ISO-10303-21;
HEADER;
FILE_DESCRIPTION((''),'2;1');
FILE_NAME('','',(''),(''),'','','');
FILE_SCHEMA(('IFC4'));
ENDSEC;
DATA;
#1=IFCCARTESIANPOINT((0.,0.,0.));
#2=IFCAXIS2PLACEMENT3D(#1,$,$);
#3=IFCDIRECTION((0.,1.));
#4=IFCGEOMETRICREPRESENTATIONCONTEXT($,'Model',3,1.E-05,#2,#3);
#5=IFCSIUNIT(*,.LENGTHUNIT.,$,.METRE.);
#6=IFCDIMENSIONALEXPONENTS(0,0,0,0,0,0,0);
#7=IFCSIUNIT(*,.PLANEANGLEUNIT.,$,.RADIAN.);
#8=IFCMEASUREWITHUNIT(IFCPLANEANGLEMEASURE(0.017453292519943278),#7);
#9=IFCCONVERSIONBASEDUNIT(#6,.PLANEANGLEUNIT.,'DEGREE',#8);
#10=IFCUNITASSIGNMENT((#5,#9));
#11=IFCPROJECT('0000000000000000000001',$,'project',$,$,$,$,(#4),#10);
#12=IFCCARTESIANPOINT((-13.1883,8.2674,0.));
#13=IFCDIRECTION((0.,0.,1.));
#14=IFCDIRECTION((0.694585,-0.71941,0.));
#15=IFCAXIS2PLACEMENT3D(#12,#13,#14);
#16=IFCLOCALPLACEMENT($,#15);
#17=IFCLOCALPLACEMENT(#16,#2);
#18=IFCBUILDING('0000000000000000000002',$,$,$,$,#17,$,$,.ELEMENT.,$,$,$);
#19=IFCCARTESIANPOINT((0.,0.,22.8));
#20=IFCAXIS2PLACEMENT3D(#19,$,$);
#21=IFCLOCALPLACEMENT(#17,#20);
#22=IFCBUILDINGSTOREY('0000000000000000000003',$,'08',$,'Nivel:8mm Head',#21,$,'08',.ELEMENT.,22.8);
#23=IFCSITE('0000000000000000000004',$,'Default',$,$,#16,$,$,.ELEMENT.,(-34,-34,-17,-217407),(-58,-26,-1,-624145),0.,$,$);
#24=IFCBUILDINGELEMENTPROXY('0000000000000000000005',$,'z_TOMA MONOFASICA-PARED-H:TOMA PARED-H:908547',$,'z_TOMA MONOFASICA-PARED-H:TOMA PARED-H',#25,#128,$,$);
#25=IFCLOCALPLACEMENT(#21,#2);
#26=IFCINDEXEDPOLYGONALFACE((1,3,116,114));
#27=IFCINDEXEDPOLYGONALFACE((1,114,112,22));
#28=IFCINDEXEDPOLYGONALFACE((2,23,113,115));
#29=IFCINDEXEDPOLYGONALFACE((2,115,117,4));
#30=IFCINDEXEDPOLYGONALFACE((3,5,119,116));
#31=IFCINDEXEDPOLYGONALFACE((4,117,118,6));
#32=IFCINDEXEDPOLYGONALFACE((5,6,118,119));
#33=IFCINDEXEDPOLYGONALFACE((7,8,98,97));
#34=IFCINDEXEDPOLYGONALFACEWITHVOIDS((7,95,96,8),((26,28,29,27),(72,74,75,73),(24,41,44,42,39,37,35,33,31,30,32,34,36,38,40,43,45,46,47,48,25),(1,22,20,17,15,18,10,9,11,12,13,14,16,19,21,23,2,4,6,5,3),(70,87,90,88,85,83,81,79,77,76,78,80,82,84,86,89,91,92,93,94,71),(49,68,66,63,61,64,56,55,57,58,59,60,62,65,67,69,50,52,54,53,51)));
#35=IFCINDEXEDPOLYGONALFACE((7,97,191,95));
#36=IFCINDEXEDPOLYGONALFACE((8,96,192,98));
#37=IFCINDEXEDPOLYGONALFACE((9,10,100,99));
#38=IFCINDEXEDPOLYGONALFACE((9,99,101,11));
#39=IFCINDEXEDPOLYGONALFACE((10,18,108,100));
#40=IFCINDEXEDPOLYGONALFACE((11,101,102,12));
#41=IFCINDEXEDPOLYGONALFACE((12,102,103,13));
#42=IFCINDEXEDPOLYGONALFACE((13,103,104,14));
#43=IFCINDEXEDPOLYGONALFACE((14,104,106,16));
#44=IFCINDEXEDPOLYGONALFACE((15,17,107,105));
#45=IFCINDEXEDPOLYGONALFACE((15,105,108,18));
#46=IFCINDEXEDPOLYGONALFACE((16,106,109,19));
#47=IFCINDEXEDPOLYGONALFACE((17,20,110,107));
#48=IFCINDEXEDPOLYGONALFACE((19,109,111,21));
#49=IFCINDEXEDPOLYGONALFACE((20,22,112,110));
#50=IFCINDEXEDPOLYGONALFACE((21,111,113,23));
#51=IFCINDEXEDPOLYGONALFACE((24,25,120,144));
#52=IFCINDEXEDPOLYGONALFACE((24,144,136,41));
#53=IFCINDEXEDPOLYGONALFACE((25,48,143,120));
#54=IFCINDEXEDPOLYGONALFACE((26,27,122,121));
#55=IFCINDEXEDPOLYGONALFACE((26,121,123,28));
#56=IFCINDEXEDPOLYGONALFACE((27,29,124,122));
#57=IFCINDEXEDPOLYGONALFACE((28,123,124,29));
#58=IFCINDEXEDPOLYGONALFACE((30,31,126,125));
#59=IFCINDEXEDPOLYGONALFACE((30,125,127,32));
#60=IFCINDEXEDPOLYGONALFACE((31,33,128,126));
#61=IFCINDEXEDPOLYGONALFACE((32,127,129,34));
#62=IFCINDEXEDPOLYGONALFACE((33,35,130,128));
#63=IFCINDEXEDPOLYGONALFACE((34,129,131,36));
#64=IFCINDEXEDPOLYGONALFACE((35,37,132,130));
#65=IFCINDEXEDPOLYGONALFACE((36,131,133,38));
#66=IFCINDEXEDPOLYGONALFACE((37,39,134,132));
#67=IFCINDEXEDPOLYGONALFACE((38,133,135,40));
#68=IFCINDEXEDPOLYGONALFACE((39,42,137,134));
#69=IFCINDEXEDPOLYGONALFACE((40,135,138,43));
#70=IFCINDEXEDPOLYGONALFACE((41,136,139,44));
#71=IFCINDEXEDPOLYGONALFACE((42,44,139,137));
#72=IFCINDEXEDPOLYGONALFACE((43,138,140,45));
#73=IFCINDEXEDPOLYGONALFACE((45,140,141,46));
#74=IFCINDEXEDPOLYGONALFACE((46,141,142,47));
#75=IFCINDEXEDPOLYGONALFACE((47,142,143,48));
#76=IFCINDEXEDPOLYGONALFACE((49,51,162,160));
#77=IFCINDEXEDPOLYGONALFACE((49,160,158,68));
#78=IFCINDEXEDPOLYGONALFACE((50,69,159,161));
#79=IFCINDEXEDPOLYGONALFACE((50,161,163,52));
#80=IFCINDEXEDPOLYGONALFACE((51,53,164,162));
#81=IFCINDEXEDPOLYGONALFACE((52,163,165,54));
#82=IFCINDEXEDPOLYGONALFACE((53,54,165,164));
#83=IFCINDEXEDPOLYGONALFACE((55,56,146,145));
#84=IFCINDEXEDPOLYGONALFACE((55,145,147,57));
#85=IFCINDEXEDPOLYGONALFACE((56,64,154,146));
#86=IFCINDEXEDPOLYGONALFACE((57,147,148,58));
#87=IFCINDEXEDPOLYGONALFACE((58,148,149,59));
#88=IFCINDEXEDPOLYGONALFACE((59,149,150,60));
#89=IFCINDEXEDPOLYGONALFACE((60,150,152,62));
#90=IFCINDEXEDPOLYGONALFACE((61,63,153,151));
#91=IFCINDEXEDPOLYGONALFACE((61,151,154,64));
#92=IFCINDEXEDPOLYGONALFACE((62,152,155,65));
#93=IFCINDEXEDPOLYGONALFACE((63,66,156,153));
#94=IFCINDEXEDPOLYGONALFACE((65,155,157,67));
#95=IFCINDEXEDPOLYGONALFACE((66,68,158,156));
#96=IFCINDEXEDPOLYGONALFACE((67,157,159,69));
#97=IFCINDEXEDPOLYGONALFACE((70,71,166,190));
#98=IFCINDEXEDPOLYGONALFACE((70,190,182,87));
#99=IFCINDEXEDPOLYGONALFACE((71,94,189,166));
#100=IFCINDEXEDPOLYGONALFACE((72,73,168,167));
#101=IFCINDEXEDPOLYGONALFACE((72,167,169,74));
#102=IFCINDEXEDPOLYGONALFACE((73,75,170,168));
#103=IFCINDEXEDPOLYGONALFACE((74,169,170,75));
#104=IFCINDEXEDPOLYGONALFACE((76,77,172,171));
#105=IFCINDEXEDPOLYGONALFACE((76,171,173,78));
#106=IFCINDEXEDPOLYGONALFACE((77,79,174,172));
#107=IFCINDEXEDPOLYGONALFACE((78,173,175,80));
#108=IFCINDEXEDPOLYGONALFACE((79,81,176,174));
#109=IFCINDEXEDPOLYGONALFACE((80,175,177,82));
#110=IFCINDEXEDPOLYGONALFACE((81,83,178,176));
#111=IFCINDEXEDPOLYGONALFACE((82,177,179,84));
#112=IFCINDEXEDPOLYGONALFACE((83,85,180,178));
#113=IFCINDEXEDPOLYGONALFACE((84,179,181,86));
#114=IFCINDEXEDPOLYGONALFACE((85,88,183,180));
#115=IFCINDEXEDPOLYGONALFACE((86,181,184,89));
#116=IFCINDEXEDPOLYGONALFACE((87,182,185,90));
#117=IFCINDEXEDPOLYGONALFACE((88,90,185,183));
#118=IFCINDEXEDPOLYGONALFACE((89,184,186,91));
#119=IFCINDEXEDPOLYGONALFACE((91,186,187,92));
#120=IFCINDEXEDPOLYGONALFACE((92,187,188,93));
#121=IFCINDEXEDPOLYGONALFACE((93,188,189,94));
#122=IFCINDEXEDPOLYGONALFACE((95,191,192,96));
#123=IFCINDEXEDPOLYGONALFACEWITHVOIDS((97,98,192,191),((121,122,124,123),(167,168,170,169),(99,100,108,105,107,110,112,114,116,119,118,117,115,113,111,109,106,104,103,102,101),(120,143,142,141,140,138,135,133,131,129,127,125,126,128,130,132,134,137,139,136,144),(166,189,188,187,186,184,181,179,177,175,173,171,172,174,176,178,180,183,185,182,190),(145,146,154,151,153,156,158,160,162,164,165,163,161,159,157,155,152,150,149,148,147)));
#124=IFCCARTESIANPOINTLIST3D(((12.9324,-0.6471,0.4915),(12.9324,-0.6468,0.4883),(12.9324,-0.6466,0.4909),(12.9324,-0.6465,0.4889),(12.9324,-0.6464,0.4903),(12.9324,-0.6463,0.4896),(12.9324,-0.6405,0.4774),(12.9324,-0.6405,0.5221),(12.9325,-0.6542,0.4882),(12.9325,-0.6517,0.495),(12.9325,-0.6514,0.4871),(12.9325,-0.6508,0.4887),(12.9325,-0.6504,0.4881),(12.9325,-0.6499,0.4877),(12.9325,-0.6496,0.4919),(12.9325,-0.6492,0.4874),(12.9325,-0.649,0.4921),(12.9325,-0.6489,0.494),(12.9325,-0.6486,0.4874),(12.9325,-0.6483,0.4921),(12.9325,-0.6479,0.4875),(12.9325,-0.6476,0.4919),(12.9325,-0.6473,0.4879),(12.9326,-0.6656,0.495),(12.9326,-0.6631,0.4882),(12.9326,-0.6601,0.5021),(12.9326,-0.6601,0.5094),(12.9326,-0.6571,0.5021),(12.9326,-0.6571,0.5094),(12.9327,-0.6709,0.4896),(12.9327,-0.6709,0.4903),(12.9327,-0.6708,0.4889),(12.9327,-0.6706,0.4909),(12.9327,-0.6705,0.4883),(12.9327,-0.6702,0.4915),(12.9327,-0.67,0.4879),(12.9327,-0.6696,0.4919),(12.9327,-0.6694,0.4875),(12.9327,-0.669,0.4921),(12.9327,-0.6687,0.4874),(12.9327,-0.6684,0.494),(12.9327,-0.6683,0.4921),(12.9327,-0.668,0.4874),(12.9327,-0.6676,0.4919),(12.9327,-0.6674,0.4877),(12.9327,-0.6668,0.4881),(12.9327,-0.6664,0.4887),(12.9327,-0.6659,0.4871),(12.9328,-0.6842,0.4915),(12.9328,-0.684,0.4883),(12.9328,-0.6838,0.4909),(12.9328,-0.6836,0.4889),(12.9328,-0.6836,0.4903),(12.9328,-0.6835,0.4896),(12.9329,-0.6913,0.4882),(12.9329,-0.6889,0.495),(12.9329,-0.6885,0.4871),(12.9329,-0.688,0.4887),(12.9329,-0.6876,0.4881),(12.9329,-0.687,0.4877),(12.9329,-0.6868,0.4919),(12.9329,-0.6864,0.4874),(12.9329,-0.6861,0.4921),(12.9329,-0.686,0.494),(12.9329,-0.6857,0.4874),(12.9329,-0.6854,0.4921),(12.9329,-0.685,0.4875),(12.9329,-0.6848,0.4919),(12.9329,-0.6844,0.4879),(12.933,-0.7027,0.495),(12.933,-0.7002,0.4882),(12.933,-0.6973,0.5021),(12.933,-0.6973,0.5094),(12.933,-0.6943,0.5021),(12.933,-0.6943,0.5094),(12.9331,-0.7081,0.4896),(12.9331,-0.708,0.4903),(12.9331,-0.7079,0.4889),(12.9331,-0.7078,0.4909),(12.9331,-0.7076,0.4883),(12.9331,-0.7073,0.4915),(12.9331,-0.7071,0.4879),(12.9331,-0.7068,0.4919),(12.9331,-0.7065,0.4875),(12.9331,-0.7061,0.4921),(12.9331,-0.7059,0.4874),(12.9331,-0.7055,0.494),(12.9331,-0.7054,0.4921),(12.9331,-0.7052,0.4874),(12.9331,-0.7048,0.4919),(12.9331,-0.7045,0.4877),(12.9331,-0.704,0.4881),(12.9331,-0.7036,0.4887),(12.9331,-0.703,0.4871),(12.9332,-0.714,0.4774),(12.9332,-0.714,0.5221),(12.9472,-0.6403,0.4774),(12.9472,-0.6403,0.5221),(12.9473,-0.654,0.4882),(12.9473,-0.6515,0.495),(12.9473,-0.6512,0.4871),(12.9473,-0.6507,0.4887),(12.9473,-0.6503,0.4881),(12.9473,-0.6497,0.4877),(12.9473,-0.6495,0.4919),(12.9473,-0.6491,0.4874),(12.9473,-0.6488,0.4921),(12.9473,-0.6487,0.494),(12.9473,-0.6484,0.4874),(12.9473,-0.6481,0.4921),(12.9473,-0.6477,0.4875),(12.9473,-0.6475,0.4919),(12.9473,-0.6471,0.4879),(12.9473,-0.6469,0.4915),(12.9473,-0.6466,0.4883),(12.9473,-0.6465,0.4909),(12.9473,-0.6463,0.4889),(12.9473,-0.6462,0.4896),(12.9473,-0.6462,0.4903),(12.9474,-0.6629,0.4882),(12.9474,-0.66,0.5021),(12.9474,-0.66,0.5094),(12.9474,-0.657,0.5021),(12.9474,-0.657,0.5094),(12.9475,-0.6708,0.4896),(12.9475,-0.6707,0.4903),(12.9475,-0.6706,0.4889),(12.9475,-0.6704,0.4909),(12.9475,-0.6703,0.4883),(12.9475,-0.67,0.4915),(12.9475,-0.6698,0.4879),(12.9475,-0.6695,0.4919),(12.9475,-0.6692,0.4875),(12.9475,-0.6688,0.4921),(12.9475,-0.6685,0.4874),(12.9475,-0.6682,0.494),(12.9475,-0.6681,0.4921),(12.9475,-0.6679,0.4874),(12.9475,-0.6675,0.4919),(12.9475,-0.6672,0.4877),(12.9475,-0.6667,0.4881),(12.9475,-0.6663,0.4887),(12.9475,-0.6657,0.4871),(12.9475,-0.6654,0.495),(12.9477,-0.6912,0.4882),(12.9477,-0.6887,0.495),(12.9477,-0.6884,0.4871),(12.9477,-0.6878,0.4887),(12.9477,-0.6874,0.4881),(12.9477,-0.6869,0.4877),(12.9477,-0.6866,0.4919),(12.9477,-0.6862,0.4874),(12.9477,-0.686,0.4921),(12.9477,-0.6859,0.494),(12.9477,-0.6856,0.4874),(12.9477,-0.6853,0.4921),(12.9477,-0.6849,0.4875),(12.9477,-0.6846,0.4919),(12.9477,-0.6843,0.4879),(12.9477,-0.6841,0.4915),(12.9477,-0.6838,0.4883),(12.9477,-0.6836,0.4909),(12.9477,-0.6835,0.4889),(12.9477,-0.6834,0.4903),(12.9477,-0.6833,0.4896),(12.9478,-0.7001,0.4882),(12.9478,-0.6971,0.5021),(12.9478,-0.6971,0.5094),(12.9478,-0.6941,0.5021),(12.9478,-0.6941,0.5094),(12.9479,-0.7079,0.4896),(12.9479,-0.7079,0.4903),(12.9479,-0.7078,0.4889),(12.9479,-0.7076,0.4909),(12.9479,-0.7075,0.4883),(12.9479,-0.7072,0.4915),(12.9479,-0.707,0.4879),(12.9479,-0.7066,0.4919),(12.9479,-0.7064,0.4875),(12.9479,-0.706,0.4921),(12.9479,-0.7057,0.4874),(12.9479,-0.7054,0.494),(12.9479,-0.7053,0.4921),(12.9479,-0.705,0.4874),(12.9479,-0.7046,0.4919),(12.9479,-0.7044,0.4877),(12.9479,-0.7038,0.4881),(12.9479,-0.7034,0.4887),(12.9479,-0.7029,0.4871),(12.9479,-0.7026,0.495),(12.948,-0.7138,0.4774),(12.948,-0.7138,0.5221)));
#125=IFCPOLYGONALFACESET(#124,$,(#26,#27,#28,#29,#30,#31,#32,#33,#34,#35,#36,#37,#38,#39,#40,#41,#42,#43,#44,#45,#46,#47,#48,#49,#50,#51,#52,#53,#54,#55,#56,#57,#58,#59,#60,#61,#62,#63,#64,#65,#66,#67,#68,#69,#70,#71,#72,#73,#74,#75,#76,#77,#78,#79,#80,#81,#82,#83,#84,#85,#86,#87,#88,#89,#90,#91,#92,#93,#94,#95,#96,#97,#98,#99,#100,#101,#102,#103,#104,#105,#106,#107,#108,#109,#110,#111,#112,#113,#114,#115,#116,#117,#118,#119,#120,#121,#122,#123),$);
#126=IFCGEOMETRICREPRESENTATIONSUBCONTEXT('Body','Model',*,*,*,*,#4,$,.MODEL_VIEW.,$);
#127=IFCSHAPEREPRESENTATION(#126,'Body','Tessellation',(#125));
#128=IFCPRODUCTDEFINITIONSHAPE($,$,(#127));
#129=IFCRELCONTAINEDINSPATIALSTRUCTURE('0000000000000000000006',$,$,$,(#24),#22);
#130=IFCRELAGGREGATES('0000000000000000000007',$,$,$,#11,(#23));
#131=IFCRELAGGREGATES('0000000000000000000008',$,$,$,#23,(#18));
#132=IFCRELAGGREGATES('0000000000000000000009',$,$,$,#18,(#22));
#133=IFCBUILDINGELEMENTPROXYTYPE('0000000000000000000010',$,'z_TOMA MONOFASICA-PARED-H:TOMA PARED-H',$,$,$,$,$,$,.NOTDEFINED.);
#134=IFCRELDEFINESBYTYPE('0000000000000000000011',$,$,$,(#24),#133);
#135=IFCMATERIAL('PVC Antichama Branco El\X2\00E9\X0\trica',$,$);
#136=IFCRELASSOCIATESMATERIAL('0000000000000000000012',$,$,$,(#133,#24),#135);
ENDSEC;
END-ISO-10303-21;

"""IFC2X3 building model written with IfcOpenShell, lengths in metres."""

from ifc_helpers import new_model, entity, si_unit, converted_unit, direction, frame, frame_2d, origin, place, context, subcontext, project, spatial, polyline, circle_curve, parameter, trimmed, segment, composite_curve, outline, extrude, source, transform, mapped, material, type_object, type_shapes, element, save


model = new_model("IFC2X3")

# Units and contexts
model_context = context("Model", 3, precision=1e-05, world=origin(), true_north=direction((0.0, 1.0)))
body_context = subcontext(model_context, "Body", "Model", "MODEL_VIEW")
ifc_project = project(units=[si_unit("LENGTHUNIT", "METRE"), converted_unit("PLANEANGLEUNIT", "DEGREE", entity("IfcPlaneAngleMeasure", 0.017453292519943278), si_unit("PLANEANGLEUNIT", "RADIAN"), dimensions=[0, 0, 0, 0, 0, 0, 0])], contexts=[model_context])

# Site, building, storey
site_placement = place(None, frame((-13.1883, 8.2674, 0.0), z_axis=(0.0, 0.0, 1.0), x_axis=(0.694585, -0.71941, 0.0)))
site = spatial("IfcSite", under=ifc_project, at=site_placement, Name="Default", CompositionType="ELEMENT", RefLatitude=(-34, -34, -17, -217407), RefLongitude=(-58, -26, -1, -624145), RefElevation=0.0)
building_placement = place(site_placement, origin())
building = spatial("IfcBuilding", under=site, at=building_placement, CompositionType="ELEMENT")
storey_placement = place(building_placement, frame((0.0, 0.0, 22.8)))
storey = spatial("IfcBuildingStorey", under=building, at=storey_placement, Name="08", ObjectType="Nivel:8mm Head", LongName="08", CompositionType="ELEMENT", Elevation=22.8)

# Building element proxy
ifc_material_1 = material(Name="PVC Antichama Branco Elétrica")
building_element_proxy_type_1 = type_object("IfcBuildingElementProxyType", Name="z_TOMA MONOFASICA-PARED-H:TOMA PARED-H", PredefinedType="NOTDEFINED", material=ifc_material_1)
shared_shape_1 = source(origin(), body_context, "Body", "SweptSolid", [
    extrude(outline(polyline([(-0.0368, -0.0223), (0.0368, -0.0223), (0.0368, 0.0223), (-0.0368, 0.0223), (-0.0368, -0.0223)]), holes=[composite_curve([segment(polyline([(0.0141, 0.0115), (0.0116, 0.0047)]), True, "CONTINUOUS"), segment(polyline([(0.0116, 0.0047), (0.0088, 0.0057)]), True, "CONTINUOUS"), segment(polyline([(0.0088, 0.0057), (0.0096, 0.0078)]), True, "CONTINUOUS"), segment(trimmed(circle_curve(frame_2d((0.0087, 0.0099), x_axis=(1.0, 0.0)), 0.0024), [parameter(27.118901)], [parameter(292.881099)], True, "PARAMETER"), False, "CONTINUOUS"), segment(polyline([(0.0108, 0.011), (0.0113, 0.0126)]), True, "CONTINUOUS"), segment(polyline([(0.0113, 0.0126), (0.0141, 0.0115)]), True, "CONTINUOUS")], self_intersect=False), composite_curve([segment(polyline([(0.0255, 0.0047), (0.023, 0.0115)]), True, "CONTINUOUS"), segment(polyline([(0.023, 0.0115), (0.0258, 0.0126)]), True, "CONTINUOUS"), segment(polyline([(0.0258, 0.0126), (0.0264, 0.011)]), True, "CONTINUOUS"), segment(trimmed(circle_curve(frame_2d((0.0285, 0.0099), x_axis=(1.0, 0.0)), 0.0024), [parameter(247.118901)], [parameter(152.881099)], True, "PARAMETER"), False, "CONTINUOUS"), segment(polyline([(0.0276, 0.0078), (0.0283, 0.0057)]), True, "CONTINUOUS"), segment(polyline([(0.0283, 0.0057), (0.0255, 0.0047)]), True, "CONTINUOUS")], self_intersect=False), polyline([(0.0201, -0.0024), (0.0201, -0.0097), (0.0171, -0.0097), (0.0171, -0.0024), (0.0201, -0.0024)]), composite_curve([segment(polyline([(-0.0141, 0.0115), (-0.0113, 0.0126)]), True, "CONTINUOUS"), segment(polyline([(-0.0113, 0.0126), (-0.0108, 0.011)]), True, "CONTINUOUS"), segment(trimmed(circle_curve(frame_2d((-0.0087, 0.0099), x_axis=(1.0, 0.0)), 0.0024), [parameter(247.118901)], [parameter(152.881099)], True, "PARAMETER"), False, "CONTINUOUS"), segment(polyline([(-0.0096, 0.0078), (-0.0088, 0.0057)]), True, "CONTINUOUS"), segment(polyline([(-0.0088, 0.0057), (-0.0116, 0.0047)]), True, "CONTINUOUS"), segment(polyline([(-0.0116, 0.0047), (-0.0141, 0.0115)]), True, "CONTINUOUS")], self_intersect=False), composite_curve([segment(polyline([(-0.0255, 0.0047), (-0.0283, 0.0057)]), True, "CONTINUOUS"), segment(polyline([(-0.0283, 0.0057), (-0.0276, 0.0078)]), True, "CONTINUOUS"), segment(trimmed(circle_curve(frame_2d((-0.0285, 0.0099), x_axis=(1.0, 0.0)), 0.0024), [parameter(27.118901)], [parameter(292.881099)], True, "PARAMETER"), False, "CONTINUOUS"), segment(polyline([(-0.0264, 0.011), (-0.0258, 0.0126)]), True, "CONTINUOUS"), segment(polyline([(-0.0258, 0.0126), (-0.023, 0.0115)]), True, "CONTINUOUS"), segment(polyline([(-0.023, 0.0115), (-0.0255, 0.0047)]), True, "CONTINUOUS")], self_intersect=False), polyline([(-0.0201, -0.0024), (-0.0171, -0.0024), (-0.0171, -0.0097), (-0.0201, -0.0097), (-0.0201, -0.0024)])]), frame((0.0, -0.005, 0.0223), z_axis=(0.0, 1.0, 0.0), x_axis=(1.0, 0.0, 0.0)), (0.0, 0.0, 1.0), 0.0148),
])
type_shapes(building_element_proxy_type_1, [shared_shape_1])
for number, where, z_axis, x_axis, name in (
    (1, (12.9426, -0.6771, 0.4774), (0.0, 0.0, 1.0), (-0.010773, 0.999942, 0.0), "z_TOMA MONOFASICA-PARED-H:TOMA PARED-H:908547"),
):
    element("IfcBuildingElementProxy", number, at=place(storey_placement, frame(where, z_axis=z_axis, x_axis=x_axis)), inside=storey, type_object=building_element_proxy_type_1, material=ifc_material_1, Name=name, ObjectType="z_TOMA MONOFASICA-PARED-H:TOMA PARED-H", context=body_context, shape_type="MappedRepresentation", body=[
        mapped(shared_shape_1, transform((0.0, 0.0, 0.0), scale=1.0)),
    ])

save(model, "model.ifc")
